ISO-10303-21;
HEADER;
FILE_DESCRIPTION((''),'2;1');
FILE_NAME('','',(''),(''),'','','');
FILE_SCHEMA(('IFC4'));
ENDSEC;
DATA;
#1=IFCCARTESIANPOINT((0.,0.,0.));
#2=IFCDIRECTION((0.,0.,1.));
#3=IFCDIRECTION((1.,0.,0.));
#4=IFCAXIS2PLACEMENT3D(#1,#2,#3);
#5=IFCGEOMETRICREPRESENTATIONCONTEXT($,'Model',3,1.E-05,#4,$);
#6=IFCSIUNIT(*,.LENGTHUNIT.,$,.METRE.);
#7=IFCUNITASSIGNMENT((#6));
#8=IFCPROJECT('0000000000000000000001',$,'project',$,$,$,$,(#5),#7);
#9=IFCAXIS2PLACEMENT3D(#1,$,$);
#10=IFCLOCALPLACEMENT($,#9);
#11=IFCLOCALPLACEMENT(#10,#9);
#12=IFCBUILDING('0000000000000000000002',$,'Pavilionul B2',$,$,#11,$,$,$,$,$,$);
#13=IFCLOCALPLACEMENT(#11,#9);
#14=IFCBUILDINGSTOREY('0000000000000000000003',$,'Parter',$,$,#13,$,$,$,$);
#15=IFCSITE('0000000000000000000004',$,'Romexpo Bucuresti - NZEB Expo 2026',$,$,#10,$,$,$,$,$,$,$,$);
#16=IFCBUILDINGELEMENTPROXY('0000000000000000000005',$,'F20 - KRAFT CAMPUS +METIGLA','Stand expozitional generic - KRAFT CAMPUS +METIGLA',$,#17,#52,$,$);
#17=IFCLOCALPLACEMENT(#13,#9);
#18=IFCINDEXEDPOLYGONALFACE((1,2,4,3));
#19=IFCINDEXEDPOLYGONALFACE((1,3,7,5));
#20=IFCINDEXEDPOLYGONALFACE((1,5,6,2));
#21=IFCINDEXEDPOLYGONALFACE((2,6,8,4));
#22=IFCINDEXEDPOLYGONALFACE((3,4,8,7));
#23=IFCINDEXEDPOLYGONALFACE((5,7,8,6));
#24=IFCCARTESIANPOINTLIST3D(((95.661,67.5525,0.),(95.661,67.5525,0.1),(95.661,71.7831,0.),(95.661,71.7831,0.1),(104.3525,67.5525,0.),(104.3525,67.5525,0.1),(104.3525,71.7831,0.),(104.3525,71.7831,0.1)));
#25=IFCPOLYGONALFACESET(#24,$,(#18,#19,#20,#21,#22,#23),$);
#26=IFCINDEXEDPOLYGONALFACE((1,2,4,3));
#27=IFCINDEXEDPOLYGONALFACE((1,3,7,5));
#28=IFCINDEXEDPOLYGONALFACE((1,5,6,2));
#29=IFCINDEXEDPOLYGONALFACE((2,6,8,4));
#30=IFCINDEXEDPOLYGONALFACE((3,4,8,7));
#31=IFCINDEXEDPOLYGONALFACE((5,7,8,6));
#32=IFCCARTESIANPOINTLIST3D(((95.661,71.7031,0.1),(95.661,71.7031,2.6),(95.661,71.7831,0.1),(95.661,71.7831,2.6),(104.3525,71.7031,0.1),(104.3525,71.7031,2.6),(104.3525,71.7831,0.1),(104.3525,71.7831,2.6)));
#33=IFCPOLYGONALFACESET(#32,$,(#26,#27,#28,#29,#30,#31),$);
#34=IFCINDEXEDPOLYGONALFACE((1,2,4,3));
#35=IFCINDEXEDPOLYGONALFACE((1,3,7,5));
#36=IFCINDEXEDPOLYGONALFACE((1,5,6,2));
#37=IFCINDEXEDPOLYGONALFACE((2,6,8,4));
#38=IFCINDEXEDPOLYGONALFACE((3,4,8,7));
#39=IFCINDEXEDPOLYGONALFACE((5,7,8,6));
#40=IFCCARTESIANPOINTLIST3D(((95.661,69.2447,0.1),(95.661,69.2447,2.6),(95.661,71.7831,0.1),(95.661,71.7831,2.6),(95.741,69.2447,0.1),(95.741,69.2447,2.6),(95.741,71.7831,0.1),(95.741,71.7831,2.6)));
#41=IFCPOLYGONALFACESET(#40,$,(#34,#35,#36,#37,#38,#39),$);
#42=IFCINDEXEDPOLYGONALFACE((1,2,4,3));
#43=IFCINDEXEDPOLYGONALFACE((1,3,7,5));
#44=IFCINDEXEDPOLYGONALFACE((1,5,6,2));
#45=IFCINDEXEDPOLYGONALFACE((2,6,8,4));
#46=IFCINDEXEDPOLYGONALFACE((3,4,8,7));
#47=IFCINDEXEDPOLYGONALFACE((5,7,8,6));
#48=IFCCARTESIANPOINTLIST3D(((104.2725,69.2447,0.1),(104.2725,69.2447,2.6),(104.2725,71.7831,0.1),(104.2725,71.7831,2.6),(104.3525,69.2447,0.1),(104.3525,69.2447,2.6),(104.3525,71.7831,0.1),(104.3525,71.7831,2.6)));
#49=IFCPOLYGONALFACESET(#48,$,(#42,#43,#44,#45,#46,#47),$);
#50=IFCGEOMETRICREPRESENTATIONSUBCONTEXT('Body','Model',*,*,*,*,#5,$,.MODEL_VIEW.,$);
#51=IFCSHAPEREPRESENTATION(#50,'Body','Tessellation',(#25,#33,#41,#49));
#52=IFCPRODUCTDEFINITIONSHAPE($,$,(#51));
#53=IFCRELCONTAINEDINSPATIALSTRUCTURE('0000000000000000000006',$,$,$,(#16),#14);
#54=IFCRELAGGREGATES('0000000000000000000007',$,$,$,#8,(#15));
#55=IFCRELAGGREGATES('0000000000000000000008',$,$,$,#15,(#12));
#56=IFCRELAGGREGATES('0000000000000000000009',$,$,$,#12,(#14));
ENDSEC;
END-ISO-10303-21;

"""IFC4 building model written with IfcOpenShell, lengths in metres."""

from ifc_helpers import new_model, si_unit, frame, frame_2d, origin, origin_with_axes, place, context, subcontext, project, spatial, rectangle, extrude, element, save


model = new_model("IFC4")

# Units and contexts
model_context = context("Model", 3, precision=1e-05, world=origin_with_axes())
body_context = subcontext(model_context, "Body", "Model", "MODEL_VIEW")
ifc_project = project(units=[si_unit("LENGTHUNIT", "METRE")], contexts=[model_context])

# Site, building, storey
site_placement = place(None, origin())
site = spatial("IfcSite", under=ifc_project, at=site_placement, Name="Romexpo Bucuresti - NZEB Expo 2026")
building_placement = place(site_placement, origin())
building = spatial("IfcBuilding", under=site, at=building_placement, Name="Pavilionul B2")
storey_placement = place(building_placement, origin())
storey = spatial("IfcBuildingStorey", under=building, at=storey_placement, Name="Parter")

# Building element proxy
for number, where, z_axis, x_axis, name in (
    (1, (95.661, 67.5525, 0.0), (0.0, 0.0, 1.0), (1.0, 0.0, 0.0), "F20 - KRAFT CAMPUS +METIGLA"),
):
    element("IfcBuildingElementProxy", number, at=place(storey_placement, frame(where, z_axis=z_axis, x_axis=x_axis)), inside=storey, Name=name, Description="Stand expozitional generic - KRAFT CAMPUS +METIGLA", context=body_context, shape_type="SweptSolid", body=[
        extrude(rectangle(XDim=8.6915, YDim=4.2305, at=frame_2d((4.3458, 2.1153))), origin(), (0.0, 0.0, 1.0), 0.1),
        extrude(rectangle(XDim=8.6915, YDim=0.08, at=frame_2d((4.3458, 4.1905))), frame((0.0, 0.0, 0.1)), (0.0, 0.0, 1.0), 2.5),
        extrude(rectangle(XDim=0.08, YDim=2.5383, at=frame_2d((0.04, 2.9614))), frame((0.0, 0.0, 0.1)), (0.0, 0.0, 1.0), 2.5),
        extrude(rectangle(XDim=0.08, YDim=2.5383, at=frame_2d((8.6515, 2.9614))), frame((0.0, 0.0, 0.1)), (0.0, 0.0, 1.0), 2.5),
    ])

save(model, "model.ifc")
